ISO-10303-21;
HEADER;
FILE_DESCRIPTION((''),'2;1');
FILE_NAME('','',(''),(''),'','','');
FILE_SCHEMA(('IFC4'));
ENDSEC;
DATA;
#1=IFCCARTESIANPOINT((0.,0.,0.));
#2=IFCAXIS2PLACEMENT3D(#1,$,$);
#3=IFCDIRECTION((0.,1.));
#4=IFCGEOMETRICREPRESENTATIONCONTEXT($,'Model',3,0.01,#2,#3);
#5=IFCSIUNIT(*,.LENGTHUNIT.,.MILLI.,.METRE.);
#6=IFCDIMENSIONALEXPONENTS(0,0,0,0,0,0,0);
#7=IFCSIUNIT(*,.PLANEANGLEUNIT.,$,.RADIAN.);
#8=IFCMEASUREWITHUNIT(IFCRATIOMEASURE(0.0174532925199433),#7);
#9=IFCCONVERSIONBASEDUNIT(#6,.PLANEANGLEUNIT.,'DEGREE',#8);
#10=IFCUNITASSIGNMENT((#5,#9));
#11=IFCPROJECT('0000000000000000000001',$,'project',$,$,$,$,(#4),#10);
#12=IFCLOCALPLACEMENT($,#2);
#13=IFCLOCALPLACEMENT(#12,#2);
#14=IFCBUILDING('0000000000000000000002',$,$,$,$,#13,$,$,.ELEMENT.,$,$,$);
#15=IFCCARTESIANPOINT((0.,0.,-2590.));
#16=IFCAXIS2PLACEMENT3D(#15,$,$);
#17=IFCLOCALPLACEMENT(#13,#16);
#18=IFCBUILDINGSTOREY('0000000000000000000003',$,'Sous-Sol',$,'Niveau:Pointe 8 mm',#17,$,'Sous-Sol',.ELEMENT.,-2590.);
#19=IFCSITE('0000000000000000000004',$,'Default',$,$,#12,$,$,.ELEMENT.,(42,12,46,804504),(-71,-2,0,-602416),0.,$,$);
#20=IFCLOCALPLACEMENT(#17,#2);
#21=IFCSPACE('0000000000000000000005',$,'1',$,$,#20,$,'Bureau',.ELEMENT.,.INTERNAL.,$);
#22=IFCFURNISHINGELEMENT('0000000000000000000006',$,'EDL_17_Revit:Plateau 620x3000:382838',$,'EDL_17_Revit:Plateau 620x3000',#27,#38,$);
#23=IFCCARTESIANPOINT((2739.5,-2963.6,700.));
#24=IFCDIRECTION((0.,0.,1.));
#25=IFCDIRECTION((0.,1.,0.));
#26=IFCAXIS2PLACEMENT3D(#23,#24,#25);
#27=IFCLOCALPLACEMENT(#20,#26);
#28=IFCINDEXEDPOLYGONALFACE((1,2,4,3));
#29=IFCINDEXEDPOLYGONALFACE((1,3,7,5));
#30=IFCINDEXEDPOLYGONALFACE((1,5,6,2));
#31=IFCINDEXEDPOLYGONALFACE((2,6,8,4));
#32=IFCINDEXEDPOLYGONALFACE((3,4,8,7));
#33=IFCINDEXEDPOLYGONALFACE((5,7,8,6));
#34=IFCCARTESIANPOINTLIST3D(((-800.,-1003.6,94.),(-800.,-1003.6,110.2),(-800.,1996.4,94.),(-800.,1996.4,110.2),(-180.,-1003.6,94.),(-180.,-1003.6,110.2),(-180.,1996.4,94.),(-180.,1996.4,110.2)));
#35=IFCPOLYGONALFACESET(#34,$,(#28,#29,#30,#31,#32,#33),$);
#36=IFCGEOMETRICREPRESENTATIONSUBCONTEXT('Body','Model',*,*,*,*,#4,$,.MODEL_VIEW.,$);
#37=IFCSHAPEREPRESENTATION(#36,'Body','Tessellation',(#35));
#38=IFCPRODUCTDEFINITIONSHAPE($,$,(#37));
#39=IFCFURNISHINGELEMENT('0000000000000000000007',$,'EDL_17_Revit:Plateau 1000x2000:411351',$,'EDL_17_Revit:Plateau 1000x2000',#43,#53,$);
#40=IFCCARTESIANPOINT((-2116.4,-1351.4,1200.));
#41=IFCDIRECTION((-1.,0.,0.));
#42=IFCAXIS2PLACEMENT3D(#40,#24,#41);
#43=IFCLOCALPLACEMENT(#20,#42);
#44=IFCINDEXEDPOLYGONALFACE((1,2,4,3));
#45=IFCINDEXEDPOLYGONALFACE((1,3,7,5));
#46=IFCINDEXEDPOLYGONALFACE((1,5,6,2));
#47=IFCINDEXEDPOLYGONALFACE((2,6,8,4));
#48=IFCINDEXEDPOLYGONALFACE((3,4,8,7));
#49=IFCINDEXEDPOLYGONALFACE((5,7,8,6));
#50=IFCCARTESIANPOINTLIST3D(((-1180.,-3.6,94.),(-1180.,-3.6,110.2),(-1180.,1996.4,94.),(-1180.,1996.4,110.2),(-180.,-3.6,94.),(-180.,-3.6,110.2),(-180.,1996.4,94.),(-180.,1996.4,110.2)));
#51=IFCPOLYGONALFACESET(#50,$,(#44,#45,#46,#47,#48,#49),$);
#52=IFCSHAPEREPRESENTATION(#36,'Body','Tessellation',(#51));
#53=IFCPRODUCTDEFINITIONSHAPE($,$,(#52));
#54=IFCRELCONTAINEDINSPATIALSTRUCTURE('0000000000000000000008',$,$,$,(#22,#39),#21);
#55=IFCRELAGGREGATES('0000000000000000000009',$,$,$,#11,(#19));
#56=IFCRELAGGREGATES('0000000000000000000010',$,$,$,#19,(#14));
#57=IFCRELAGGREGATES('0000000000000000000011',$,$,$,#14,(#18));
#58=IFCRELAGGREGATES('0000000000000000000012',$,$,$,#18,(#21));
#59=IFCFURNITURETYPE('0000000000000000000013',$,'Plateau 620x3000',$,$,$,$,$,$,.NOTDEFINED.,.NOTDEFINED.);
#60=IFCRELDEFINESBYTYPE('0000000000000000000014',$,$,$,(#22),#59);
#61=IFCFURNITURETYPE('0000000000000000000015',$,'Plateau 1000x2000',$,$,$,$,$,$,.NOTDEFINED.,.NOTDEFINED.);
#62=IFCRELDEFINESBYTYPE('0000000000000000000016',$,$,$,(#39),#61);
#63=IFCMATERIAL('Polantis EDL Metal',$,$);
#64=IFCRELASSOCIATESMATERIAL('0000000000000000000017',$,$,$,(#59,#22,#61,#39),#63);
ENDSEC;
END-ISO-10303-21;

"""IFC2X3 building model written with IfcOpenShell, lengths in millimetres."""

from ifc_helpers import new_model, entity, si_unit, converted_unit, direction, frame, frame_2d, origin, place, context, subcontext, project, spatial, rectangle, extrude, source, transform, mapped, material, type_object, type_shapes, element, save


model = new_model("IFC2X3")

# Units and contexts
model_context = context("Model", 3, precision=0.01, world=origin(), true_north=direction((0.0, 1.0)))
body_context = subcontext(model_context, "Body", "Model", "MODEL_VIEW")
ifc_project = project(units=[si_unit("LENGTHUNIT", "METRE", prefix="MILLI"), converted_unit("PLANEANGLEUNIT", "DEGREE", entity("IfcRatioMeasure", 0.0174532925199433), si_unit("PLANEANGLEUNIT", "RADIAN"), dimensions=[0, 0, 0, 0, 0, 0, 0])], contexts=[model_context])

# Site, building, storey
site_placement = place(None, origin())
site = spatial("IfcSite", under=ifc_project, at=site_placement, Name="Default", CompositionType="ELEMENT", RefLatitude=(42, 12, 46, 804504), RefLongitude=(-71, -2, 0, -602416), RefElevation=0.0)
building_placement = place(site_placement, origin())
building = spatial("IfcBuilding", under=site, at=building_placement, CompositionType="ELEMENT")
storey_placement = place(building_placement, frame((0.0, 0.0, -2590.0)))
storey = spatial("IfcBuildingStorey", under=building, at=storey_placement, Name="Sous-Sol", ObjectType="Niveau:Pointe 8 mm", LongName="Sous-Sol", CompositionType="ELEMENT", Elevation=-2590.0)

# Shared definitions
space_placement = place(storey_placement, origin())
space = spatial("IfcSpace", under=storey, at=space_placement, Name="1", LongName="Bureau", CompositionType="ELEMENT", InteriorOrExteriorSpace="INTERNAL")

# Furnishing elements
ifc_material_1 = material(Name="Polantis EDL Metal")
furniture_type_1 = type_object("IfcFurnitureType", Name="Plateau 620x3000", material=ifc_material_1)
shared_shape_1 = source(origin(), body_context, "Body", "SweptSolid", [
    extrude(rectangle(XDim=3000.0, YDim=620.0, at=frame_2d((0.0, 0.0), x_axis=(1.0, 0.0))), frame((-490.0, 496.4, 94.0), z_axis=(0.0, 0.0, 1.0), x_axis=(0.0, -1.0, 0.0)), (0.0, 0.0, 1.0), 16.2),
])
type_shapes(furniture_type_1, [shared_shape_1])
furnishing_1_placement = place(space_placement, frame((2739.5, -2963.6, 700.0), z_axis=(0.0, 0.0, 1.0), x_axis=(0.0, 1.0, 0.0)))
element("IfcFurnishingElement", 1, at=furnishing_1_placement, inside=space, type_object=furniture_type_1, material=ifc_material_1, Name="EDL_17_Revit:Plateau 620x3000:382838", ObjectType="EDL_17_Revit:Plateau 620x3000", context=body_context, shape_type="MappedRepresentation", body=[
    mapped(shared_shape_1, transform((0.0, 0.0, 0.0), scale=1.0)),
])
furniture_type_2 = type_object("IfcFurnitureType", Name="Plateau 1000x2000", material=ifc_material_1)
shared_shape_2 = source(origin(), body_context, "Body", "SweptSolid", [
    extrude(rectangle(XDim=2000.0, YDim=1000.0, at=frame_2d((0.0, 0.0), x_axis=(1.0, 0.0))), frame((-680.0, 996.4, 94.0), z_axis=(0.0, 0.0, 1.0), x_axis=(0.0, -1.0, 0.0)), (0.0, 0.0, 1.0), 16.2),
])
type_shapes(furniture_type_2, [shared_shape_2])
furnishing_2_placement = place(space_placement, frame((-2116.4, -1351.4, 1200.0), z_axis=(0.0, 0.0, 1.0), x_axis=(-1.0, 0.0, 0.0)))
element("IfcFurnishingElement", 2, at=furnishing_2_placement, inside=space, type_object=furniture_type_2, material=ifc_material_1, Name="EDL_17_Revit:Plateau 1000x2000:411351", ObjectType="EDL_17_Revit:Plateau 1000x2000", context=body_context, shape_type="MappedRepresentation", body=[
    mapped(shared_shape_2, transform((0.0, 0.0, 0.0), scale=1.0)),
])

save(model, "model.ifc")
